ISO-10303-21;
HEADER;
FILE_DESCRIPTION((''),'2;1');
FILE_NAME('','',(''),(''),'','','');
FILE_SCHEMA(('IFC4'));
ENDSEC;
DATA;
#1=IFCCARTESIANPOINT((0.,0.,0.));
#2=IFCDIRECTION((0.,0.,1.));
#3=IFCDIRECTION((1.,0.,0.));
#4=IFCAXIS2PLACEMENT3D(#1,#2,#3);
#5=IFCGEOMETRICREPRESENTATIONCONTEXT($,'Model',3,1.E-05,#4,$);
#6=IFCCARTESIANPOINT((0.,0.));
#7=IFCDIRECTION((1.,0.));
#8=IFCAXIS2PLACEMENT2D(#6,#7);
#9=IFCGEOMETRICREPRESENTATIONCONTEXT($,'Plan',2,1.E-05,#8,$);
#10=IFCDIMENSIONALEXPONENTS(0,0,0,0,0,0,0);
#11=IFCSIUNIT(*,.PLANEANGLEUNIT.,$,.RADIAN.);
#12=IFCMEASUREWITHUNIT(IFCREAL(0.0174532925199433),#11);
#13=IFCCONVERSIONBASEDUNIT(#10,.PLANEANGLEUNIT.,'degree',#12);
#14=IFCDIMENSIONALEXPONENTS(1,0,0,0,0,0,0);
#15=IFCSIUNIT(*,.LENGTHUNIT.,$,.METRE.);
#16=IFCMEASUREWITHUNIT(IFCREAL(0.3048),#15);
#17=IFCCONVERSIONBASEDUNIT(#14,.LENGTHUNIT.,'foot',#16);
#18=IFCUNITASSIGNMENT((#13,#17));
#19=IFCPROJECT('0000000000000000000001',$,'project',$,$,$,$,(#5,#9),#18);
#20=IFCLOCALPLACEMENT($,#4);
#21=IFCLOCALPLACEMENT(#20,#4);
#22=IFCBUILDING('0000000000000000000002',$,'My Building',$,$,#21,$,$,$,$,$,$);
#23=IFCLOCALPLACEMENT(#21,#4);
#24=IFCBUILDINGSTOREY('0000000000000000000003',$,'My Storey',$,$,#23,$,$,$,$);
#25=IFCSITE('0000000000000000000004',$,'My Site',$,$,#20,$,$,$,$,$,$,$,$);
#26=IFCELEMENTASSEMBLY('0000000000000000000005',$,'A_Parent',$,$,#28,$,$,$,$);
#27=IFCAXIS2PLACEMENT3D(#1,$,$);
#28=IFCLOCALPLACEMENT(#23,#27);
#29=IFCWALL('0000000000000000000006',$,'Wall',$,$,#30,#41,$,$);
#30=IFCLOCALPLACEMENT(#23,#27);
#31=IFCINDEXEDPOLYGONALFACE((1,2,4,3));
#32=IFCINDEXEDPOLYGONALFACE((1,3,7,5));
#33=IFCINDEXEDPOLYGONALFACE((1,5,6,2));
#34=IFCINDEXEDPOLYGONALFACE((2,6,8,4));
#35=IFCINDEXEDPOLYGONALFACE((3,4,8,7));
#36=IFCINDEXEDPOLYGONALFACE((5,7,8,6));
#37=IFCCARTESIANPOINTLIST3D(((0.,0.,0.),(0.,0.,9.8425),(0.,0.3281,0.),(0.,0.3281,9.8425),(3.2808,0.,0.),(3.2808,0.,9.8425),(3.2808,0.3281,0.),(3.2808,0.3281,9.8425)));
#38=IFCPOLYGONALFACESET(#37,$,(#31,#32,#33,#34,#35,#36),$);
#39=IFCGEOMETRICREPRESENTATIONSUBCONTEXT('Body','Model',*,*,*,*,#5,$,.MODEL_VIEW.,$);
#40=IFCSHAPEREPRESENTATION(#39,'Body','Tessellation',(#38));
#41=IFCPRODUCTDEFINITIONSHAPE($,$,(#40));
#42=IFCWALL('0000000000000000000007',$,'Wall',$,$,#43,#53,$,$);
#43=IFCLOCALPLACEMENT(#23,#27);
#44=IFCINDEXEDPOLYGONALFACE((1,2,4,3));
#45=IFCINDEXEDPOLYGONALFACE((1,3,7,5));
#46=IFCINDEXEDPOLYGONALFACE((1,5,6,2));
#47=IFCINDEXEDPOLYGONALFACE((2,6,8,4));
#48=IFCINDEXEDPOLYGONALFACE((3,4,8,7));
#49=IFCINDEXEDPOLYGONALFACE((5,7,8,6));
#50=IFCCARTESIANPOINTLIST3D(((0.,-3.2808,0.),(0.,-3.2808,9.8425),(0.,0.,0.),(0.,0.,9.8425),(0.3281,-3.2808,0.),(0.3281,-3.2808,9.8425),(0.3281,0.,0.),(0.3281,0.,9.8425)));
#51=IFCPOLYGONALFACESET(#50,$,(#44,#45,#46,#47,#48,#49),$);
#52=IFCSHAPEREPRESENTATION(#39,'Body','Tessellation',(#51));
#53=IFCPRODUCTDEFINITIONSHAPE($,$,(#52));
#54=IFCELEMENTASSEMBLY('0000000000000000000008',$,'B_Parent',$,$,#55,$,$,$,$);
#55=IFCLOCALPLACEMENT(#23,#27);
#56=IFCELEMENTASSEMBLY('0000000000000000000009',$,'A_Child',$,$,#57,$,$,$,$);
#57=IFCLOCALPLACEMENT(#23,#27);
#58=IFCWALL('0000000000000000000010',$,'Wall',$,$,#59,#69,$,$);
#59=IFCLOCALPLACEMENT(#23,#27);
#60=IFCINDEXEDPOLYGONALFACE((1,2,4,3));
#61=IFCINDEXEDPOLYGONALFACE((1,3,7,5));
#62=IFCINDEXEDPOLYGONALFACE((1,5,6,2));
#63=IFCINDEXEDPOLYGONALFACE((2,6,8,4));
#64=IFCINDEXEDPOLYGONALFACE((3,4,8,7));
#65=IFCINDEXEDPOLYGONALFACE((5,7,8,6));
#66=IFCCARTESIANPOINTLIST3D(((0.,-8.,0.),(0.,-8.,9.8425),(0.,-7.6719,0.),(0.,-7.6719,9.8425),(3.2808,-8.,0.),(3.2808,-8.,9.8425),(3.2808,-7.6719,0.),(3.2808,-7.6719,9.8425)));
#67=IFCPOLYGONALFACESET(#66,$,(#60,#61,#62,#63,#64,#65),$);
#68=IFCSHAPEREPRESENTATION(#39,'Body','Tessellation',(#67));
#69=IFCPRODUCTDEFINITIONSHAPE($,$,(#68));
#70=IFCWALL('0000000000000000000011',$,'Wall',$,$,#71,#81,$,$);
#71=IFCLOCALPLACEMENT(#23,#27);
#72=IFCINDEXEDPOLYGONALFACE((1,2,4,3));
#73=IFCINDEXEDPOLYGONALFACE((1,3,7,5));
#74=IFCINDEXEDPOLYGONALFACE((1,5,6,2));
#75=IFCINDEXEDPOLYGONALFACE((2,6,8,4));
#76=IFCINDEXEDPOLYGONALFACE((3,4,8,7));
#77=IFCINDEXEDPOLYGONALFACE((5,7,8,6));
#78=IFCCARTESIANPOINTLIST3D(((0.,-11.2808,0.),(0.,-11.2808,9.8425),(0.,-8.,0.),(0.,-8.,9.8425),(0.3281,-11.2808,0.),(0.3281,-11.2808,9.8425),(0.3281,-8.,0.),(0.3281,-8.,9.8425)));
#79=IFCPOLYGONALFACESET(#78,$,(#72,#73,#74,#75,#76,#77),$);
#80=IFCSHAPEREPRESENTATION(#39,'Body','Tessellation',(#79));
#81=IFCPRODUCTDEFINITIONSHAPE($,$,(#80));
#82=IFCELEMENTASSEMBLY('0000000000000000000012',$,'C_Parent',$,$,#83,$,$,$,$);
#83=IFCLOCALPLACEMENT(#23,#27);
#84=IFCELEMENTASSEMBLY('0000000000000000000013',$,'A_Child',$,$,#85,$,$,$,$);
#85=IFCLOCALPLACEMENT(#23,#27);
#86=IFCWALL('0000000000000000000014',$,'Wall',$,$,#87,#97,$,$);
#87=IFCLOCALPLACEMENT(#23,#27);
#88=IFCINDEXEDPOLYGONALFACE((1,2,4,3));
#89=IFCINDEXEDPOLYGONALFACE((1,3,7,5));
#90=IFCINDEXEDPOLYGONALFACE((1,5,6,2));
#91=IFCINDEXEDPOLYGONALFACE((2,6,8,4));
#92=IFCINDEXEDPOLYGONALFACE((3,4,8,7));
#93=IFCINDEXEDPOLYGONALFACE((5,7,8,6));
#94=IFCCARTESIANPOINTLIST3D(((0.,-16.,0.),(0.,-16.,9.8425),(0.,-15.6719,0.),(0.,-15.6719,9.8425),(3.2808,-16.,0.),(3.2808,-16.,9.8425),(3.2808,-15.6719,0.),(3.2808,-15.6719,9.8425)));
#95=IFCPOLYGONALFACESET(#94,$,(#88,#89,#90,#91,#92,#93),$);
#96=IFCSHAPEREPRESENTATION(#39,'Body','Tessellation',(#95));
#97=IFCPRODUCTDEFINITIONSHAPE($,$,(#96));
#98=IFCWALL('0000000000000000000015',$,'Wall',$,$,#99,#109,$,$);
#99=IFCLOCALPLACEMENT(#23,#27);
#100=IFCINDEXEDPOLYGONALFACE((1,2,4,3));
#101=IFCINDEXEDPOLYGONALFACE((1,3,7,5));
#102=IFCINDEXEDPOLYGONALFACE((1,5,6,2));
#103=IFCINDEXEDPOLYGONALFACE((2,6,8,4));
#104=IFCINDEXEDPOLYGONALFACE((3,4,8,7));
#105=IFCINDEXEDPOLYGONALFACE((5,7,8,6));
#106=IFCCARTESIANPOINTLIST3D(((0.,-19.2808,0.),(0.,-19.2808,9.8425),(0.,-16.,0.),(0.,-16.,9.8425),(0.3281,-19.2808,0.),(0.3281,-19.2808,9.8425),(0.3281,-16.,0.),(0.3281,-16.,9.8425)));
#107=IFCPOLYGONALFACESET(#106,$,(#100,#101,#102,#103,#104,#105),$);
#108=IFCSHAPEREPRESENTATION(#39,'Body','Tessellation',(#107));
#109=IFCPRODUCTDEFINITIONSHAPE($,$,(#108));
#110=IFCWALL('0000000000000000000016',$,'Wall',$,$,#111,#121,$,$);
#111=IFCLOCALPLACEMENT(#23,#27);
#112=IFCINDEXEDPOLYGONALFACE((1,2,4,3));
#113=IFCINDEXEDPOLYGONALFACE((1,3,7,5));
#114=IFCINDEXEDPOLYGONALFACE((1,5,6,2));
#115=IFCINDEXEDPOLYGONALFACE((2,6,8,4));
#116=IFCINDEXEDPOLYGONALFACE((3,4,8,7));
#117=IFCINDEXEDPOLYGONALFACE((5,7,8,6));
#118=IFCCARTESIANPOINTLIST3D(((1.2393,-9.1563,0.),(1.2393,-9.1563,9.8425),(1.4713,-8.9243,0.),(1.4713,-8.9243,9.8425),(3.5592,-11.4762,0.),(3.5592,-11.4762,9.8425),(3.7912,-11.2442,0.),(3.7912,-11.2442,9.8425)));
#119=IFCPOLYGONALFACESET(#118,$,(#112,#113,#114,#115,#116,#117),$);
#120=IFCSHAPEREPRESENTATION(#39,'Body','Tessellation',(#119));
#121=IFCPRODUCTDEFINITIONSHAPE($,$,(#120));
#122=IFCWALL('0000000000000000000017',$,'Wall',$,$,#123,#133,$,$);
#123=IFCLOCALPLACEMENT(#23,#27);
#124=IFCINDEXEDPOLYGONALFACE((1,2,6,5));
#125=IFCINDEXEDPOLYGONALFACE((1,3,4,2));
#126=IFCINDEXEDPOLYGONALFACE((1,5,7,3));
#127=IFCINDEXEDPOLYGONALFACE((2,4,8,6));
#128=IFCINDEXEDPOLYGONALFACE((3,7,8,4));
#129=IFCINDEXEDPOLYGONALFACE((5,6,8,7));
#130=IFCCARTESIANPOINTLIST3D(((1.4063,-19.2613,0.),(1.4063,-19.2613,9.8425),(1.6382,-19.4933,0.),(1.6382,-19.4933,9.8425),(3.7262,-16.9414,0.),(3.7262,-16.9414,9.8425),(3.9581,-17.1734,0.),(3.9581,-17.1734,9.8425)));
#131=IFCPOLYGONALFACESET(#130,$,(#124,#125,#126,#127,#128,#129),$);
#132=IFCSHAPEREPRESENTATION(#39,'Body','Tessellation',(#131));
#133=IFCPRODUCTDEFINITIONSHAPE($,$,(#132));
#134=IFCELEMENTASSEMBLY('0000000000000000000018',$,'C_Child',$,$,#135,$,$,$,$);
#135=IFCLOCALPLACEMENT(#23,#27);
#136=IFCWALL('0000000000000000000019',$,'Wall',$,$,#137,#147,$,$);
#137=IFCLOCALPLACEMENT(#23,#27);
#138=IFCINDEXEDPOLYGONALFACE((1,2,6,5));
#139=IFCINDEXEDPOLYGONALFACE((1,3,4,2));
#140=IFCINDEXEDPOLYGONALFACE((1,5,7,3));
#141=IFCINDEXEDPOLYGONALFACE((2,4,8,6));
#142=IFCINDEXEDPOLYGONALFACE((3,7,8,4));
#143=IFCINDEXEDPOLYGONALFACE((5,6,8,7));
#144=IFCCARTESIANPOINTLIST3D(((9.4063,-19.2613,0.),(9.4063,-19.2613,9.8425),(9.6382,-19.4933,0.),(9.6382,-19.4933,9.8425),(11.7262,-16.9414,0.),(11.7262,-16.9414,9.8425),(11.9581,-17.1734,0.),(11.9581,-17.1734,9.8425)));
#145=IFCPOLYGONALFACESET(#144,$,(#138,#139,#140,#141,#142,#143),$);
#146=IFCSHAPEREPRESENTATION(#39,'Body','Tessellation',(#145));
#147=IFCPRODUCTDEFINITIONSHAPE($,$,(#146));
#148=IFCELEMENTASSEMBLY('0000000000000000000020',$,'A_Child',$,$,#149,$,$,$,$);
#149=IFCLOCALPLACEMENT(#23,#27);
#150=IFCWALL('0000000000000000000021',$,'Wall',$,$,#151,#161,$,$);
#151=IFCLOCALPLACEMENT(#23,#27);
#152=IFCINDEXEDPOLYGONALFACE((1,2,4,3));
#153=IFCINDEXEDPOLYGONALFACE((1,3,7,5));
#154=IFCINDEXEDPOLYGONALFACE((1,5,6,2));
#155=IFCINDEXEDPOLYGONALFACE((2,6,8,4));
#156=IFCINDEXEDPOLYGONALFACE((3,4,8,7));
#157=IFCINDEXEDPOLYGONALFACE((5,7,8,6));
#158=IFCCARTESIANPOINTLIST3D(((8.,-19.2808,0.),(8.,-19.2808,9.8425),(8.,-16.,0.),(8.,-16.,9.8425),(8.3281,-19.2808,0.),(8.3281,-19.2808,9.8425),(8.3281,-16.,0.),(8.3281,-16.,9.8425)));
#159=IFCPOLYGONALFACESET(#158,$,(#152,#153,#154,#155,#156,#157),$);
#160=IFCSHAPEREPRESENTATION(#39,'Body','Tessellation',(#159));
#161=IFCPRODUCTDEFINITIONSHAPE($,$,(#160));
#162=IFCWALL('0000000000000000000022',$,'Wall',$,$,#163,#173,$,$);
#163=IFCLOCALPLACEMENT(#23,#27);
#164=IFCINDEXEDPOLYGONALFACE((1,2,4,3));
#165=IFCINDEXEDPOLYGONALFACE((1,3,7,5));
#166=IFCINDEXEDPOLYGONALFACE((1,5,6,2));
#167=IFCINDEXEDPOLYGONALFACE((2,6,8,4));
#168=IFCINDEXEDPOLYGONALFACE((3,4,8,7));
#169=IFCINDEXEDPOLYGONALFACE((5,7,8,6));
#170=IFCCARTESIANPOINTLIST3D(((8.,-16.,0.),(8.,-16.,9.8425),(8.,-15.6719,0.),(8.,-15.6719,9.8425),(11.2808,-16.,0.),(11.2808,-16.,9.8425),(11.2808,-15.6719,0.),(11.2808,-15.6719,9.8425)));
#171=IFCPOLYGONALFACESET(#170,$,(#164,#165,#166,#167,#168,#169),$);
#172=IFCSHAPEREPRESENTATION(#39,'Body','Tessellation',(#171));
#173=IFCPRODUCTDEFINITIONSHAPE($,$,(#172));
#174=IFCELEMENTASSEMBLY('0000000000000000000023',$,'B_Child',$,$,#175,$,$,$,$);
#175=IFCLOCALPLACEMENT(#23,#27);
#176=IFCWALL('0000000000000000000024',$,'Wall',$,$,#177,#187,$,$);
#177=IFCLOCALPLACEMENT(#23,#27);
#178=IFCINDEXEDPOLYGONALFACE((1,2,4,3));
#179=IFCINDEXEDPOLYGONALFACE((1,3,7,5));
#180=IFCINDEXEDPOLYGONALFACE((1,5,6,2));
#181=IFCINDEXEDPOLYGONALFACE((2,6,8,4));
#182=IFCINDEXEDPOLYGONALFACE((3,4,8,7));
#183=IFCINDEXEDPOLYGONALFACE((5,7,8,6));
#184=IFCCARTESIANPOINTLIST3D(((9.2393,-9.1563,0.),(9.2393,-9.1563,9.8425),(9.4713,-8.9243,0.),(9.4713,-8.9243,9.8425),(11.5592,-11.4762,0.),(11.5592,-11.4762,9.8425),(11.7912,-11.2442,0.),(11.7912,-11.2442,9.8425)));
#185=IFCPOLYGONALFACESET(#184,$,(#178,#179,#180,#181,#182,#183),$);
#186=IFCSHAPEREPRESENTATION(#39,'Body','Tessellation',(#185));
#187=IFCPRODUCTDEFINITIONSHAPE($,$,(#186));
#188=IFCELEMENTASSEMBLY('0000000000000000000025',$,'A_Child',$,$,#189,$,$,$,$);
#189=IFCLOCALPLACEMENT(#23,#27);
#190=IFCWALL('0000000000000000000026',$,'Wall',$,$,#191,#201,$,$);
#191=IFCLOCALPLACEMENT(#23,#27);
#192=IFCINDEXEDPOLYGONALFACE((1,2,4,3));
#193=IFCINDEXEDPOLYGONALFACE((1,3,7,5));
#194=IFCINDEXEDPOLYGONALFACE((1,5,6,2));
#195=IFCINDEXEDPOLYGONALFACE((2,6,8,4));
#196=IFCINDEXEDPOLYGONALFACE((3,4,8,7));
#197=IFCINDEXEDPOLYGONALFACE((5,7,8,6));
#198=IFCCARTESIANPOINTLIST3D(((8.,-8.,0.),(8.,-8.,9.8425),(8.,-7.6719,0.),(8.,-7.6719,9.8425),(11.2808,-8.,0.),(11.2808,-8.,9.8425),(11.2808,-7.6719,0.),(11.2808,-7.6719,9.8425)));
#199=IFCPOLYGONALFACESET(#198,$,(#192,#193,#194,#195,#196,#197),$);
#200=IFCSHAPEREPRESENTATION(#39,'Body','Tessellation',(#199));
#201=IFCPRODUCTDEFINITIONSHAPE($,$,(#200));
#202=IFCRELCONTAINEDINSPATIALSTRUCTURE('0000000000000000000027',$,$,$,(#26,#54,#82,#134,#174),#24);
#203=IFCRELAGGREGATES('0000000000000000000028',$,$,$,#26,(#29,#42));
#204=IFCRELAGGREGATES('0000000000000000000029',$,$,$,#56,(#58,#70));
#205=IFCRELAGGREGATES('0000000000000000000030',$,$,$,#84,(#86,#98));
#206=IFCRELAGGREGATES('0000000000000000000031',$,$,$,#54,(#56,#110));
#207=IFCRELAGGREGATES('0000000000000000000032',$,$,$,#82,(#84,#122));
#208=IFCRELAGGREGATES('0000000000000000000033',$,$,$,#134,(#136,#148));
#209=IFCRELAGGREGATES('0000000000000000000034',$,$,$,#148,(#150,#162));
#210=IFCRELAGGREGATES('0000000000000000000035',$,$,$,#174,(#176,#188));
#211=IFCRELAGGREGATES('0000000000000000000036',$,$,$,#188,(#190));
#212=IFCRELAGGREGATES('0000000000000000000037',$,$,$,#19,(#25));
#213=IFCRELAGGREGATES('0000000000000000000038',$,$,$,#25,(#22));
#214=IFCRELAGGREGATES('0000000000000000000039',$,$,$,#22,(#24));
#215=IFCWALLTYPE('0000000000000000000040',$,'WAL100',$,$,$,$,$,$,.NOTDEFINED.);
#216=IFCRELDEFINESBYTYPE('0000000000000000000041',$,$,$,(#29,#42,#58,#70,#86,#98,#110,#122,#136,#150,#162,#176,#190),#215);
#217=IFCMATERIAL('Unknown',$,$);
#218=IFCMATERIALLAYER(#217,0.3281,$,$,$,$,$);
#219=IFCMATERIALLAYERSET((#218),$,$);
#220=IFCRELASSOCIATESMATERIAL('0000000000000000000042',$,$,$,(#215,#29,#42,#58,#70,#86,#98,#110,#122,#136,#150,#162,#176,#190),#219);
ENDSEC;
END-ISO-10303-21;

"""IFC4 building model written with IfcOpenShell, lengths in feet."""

from ifc_helpers import new_model, entity, si_unit, converted_unit, frame, origin_with_axes, origin_2d_with_axis, place, context, subcontext, project, spatial, indexed_curve, outline, extrude, material, layer, layer_set, layer_usage, type_object, element, aggregate, save


model = new_model("IFC4")

# Units and contexts
model_context = context("Model", 3, precision=1e-05, world=origin_with_axes())
plan_context = context("Plan", 2, precision=1e-05, world=origin_2d_with_axis())
body_context = subcontext(model_context, "Body", "Model", "MODEL_VIEW")
ifc_project = project(units=[converted_unit("PLANEANGLEUNIT", "degree", entity("IfcReal", 0.0174532925199433), si_unit("PLANEANGLEUNIT", "RADIAN"), dimensions=[0, 0, 0, 0, 0, 0, 0]), converted_unit("LENGTHUNIT", "foot", entity("IfcReal", 0.3048), si_unit("LENGTHUNIT", "METRE"), dimensions=[1, 0, 0, 0, 0, 0, 0])], contexts=[model_context, plan_context])

# Site, building, storey
site_placement = place(None, origin_with_axes())
site = spatial("IfcSite", under=ifc_project, at=site_placement, Name="My Site")
building_placement = place(site_placement, origin_with_axes())
building = spatial("IfcBuilding", under=site, at=building_placement, Name="My Building")
storey_placement = place(building_placement, origin_with_axes())
storey = spatial("IfcBuildingStorey", under=building, at=storey_placement, Name="My Storey")

# Element assembly, walls
assembly_1_placement = place(storey_placement, origin_with_axes())
assembly_1 = element("IfcElementAssembly", 1, at=assembly_1_placement, inside=storey, Name="A_Parent")
ifc_material = material(Name="Unknown")
ifc_layer = layer(ifc_material, 0.3281)
ifc_layer_set = layer_set([ifc_layer])
ifc_layer_usage_1 = layer_usage(ifc_layer_set, "AXIS2", "POSITIVE", 0.0)
wall_type = type_object("IfcWallType", Name="WAL100", PredefinedType="NOTDEFINED", material=ifc_layer_set)
wall_1_placement = place(assembly_1_placement, origin_with_axes())
wall_1 = element("IfcWall", 2, at=wall_1_placement, type_object=wall_type, material=ifc_layer_usage_1, Name="Wall", context=body_context, shape_type="SweptSolid", body=[
    extrude(outline(indexed_curve([(0.0, 0.0), (0.0, 0.3281), (3.2808, 0.3281), (3.2808, 0.0), (0.0, 0.0)], self_intersect=False)), origin_with_axes(), (0.0, 0.0, 1.0), 9.8425),
])
ifc_layer_usage_2 = layer_usage(ifc_layer_set, "AXIS2", "POSITIVE", 0.0)
wall_2_placement = place(assembly_1_placement, frame((0.0, 0.0, 0.0), z_axis=(0.0, 0.0, 1.0), x_axis=(0.0, -1.0, 0.0)))
wall_2 = element("IfcWall", 3, at=wall_2_placement, type_object=wall_type, material=ifc_layer_usage_2, Name="Wall", context=body_context, shape_type="SweptSolid", body=[
    extrude(outline(indexed_curve([(0.0, 0.0), (0.0, 0.3281), (3.2808, 0.3281), (3.2808, 0.0), (0.0, 0.0)], self_intersect=False)), origin_with_axes(), (0.0, 0.0, 1.0), 9.8425),
])
aggregate(assembly_1, [wall_1, wall_2])

# Element assemblies, walls
assembly_2_placement = place(storey_placement, origin_with_axes())
assembly_2 = element("IfcElementAssembly", 4, at=assembly_2_placement, inside=storey, Name="B_Parent")
assembly_3_placement = place(assembly_2_placement, frame((0.0, -8.0, 0.0), z_axis=(0.0, 0.0, 1.0), x_axis=(1.0, 0.0, 0.0)))
assembly_3 = element("IfcElementAssembly", 5, at=assembly_3_placement, Name="A_Child")
ifc_layer_usage_3 = layer_usage(ifc_layer_set, "AXIS2", "POSITIVE", 0.0)
wall_3_placement = place(assembly_3_placement, origin_with_axes())
wall_3 = element("IfcWall", 6, at=wall_3_placement, type_object=wall_type, material=ifc_layer_usage_3, Name="Wall", context=body_context, shape_type="SweptSolid", body=[
    extrude(outline(indexed_curve([(0.0, 0.0), (0.0, 0.3281), (3.2808, 0.3281), (3.2808, 0.0), (0.0, 0.0)], self_intersect=False)), origin_with_axes(), (0.0, 0.0, 1.0), 9.8425),
])
ifc_layer_usage_4 = layer_usage(ifc_layer_set, "AXIS2", "POSITIVE", 0.0)
wall_4_placement = place(assembly_3_placement, frame((0.0, 0.0, 0.0), z_axis=(0.0, 0.0, 1.0), x_axis=(0.0, -1.0, 0.0)))
wall_4 = element("IfcWall", 7, at=wall_4_placement, type_object=wall_type, material=ifc_layer_usage_4, Name="Wall", context=body_context, shape_type="SweptSolid", body=[
    extrude(outline(indexed_curve([(0.0, 0.0), (0.0, 0.3281), (3.2808, 0.3281), (3.2808, 0.0), (0.0, 0.0)], self_intersect=False)), origin_with_axes(), (0.0, 0.0, 1.0), 9.8425),
])
aggregate(assembly_3, [wall_3, wall_4])
assembly_4_placement = place(storey_placement, origin_with_axes())
assembly_4 = element("IfcElementAssembly", 8, at=assembly_4_placement, inside=storey, Name="C_Parent")
assembly_5_placement = place(assembly_4_placement, frame((0.0, -16.0, 0.0), z_axis=(0.0, 0.0, 1.0), x_axis=(1.0, 0.0, 0.0)))
assembly_5 = element("IfcElementAssembly", 9, at=assembly_5_placement, Name="A_Child")
ifc_layer_usage_5 = layer_usage(ifc_layer_set, "AXIS2", "POSITIVE", 0.0)
wall_5_placement = place(assembly_5_placement, origin_with_axes())
wall_5 = element("IfcWall", 10, at=wall_5_placement, type_object=wall_type, material=ifc_layer_usage_5, Name="Wall", context=body_context, shape_type="SweptSolid", body=[
    extrude(outline(indexed_curve([(0.0, 0.0), (0.0, 0.3281), (3.2808, 0.3281), (3.2808, 0.0), (0.0, 0.0)], self_intersect=False)), origin_with_axes(), (0.0, 0.0, 1.0), 9.8425),
])
ifc_layer_usage_6 = layer_usage(ifc_layer_set, "AXIS2", "POSITIVE", 0.0)
wall_6_placement = place(assembly_5_placement, frame((0.0, 0.0, 0.0), z_axis=(0.0, 0.0, 1.0), x_axis=(0.0, -1.0, 0.0)))
wall_6 = element("IfcWall", 11, at=wall_6_placement, type_object=wall_type, material=ifc_layer_usage_6, Name="Wall", context=body_context, shape_type="SweptSolid", body=[
    extrude(outline(indexed_curve([(0.0, 0.0), (0.0, 0.3281), (3.2808, 0.3281), (3.2808, 0.0), (0.0, 0.0)], self_intersect=False)), origin_with_axes(), (0.0, 0.0, 1.0), 9.8425),
])
aggregate(assembly_5, [wall_5, wall_6])

# Walls
ifc_layer_usage_7 = layer_usage(ifc_layer_set, "AXIS2", "POSITIVE", 0.0)
wall_7_placement = place(assembly_2_placement, frame((1.2393, -9.1563, 0.0), z_axis=(0.0, 0.0, 1.0), x_axis=(0.707107, -0.707107, 0.0)))
wall_7 = element("IfcWall", 12, at=wall_7_placement, type_object=wall_type, material=ifc_layer_usage_7, Name="Wall", context=body_context, shape_type="SweptSolid", body=[
    extrude(outline(indexed_curve([(0.0, 0.0), (0.0, 0.3281), (3.2808, 0.3281), (3.2808, 0.0), (0.0, 0.0)], self_intersect=False)), origin_with_axes(), (0.0, 0.0, 1.0), 9.8425),
])
aggregate(assembly_2, [assembly_3, wall_7])
ifc_layer_usage_8 = layer_usage(ifc_layer_set, "AXIS2", "POSITIVE", 0.0)
wall_8_placement = place(assembly_4_placement, frame((1.6382, -19.4933, 0.0), z_axis=(0.0, 0.0, 1.0), x_axis=(0.707107, 0.707107, 0.0)))
wall_8 = element("IfcWall", 13, at=wall_8_placement, type_object=wall_type, material=ifc_layer_usage_8, Name="Wall", context=body_context, shape_type="SweptSolid", body=[
    extrude(outline(indexed_curve([(0.0, 0.0), (0.0, 0.3281), (3.2808, 0.3281), (3.2808, 0.0), (0.0, 0.0)], self_intersect=False)), origin_with_axes(), (0.0, 0.0, 1.0), 9.8425),
])
aggregate(assembly_4, [assembly_5, wall_8])

# Element assemblies, walls
assembly_6_placement = place(storey_placement, frame((8.0, 0.0, 0.0), z_axis=(0.0, 0.0, 1.0), x_axis=(1.0, 0.0, 0.0)))
assembly_6 = element("IfcElementAssembly", 14, at=assembly_6_placement, inside=storey, Name="C_Child")
ifc_layer_usage_9 = layer_usage(ifc_layer_set, "AXIS2", "POSITIVE", 0.0)
wall_9_placement = place(assembly_6_placement, frame((1.6382, -19.4933, 0.0), z_axis=(0.0, 0.0, 1.0), x_axis=(0.707107, 0.707107, 0.0)))
wall_9 = element("IfcWall", 15, at=wall_9_placement, type_object=wall_type, material=ifc_layer_usage_9, Name="Wall", context=body_context, shape_type="SweptSolid", body=[
    extrude(outline(indexed_curve([(0.0, 0.0), (0.0, 0.3281), (3.2808, 0.3281), (3.2808, 0.0), (0.0, 0.0)], self_intersect=False)), origin_with_axes(), (0.0, 0.0, 1.0), 9.8425),
])
assembly_7_placement = place(assembly_6_placement, frame((0.0, -16.0, 0.0), z_axis=(0.0, 0.0, 1.0), x_axis=(1.0, 0.0, 0.0)))
assembly_7 = element("IfcElementAssembly", 16, at=assembly_7_placement, Name="A_Child")
aggregate(assembly_6, [wall_9, assembly_7])
ifc_layer_usage_10 = layer_usage(ifc_layer_set, "AXIS2", "POSITIVE", 0.0)
wall_10_placement = place(assembly_7_placement, frame((0.0, 0.0, 0.0), z_axis=(0.0, 0.0, 1.0), x_axis=(0.0, -1.0, 0.0)))
wall_10 = element("IfcWall", 17, at=wall_10_placement, type_object=wall_type, material=ifc_layer_usage_10, Name="Wall", context=body_context, shape_type="SweptSolid", body=[
    extrude(outline(indexed_curve([(0.0, 0.0), (0.0, 0.3281), (3.2808, 0.3281), (3.2808, 0.0), (0.0, 0.0)], self_intersect=False)), origin_with_axes(), (0.0, 0.0, 1.0), 9.8425),
])
ifc_layer_usage_11 = layer_usage(ifc_layer_set, "AXIS2", "POSITIVE", 0.0)
wall_11_placement = place(assembly_7_placement, origin_with_axes())
wall_11 = element("IfcWall", 18, at=wall_11_placement, type_object=wall_type, material=ifc_layer_usage_11, Name="Wall", context=body_context, shape_type="SweptSolid", body=[
    extrude(outline(indexed_curve([(0.0, 0.0), (0.0, 0.3281), (3.2808, 0.3281), (3.2808, 0.0), (0.0, 0.0)], self_intersect=False)), origin_with_axes(), (0.0, 0.0, 1.0), 9.8425),
])
aggregate(assembly_7, [wall_10, wall_11])
assembly_8_placement = place(storey_placement, frame((8.0, 0.0, 0.0), z_axis=(0.0, 0.0, 1.0), x_axis=(1.0, 0.0, 0.0)))
assembly_8 = element("IfcElementAssembly", 19, at=assembly_8_placement, inside=storey, Name="B_Child")
ifc_layer_usage_12 = layer_usage(ifc_layer_set, "AXIS2", "POSITIVE", 0.0)
wall_12_placement = place(assembly_8_placement, frame((1.2393, -9.1563, 0.0), z_axis=(0.0, 0.0, 1.0), x_axis=(0.707107, -0.707107, 0.0)))
wall_12 = element("IfcWall", 20, at=wall_12_placement, type_object=wall_type, material=ifc_layer_usage_12, Name="Wall", context=body_context, shape_type="SweptSolid", body=[
    extrude(outline(indexed_curve([(0.0, 0.0), (0.0, 0.3281), (3.2808, 0.3281), (3.2808, 0.0), (0.0, 0.0)], self_intersect=False)), origin_with_axes(), (0.0, 0.0, 1.0), 9.8425),
])
assembly_9_placement = place(assembly_8_placement, frame((0.0, -8.0, 0.0), z_axis=(0.0, 0.0, 1.0), x_axis=(1.0, 0.0, 0.0)))
assembly_9 = element("IfcElementAssembly", 21, at=assembly_9_placement, Name="A_Child")
aggregate(assembly_8, [wall_12, assembly_9])
ifc_layer_usage_13 = layer_usage(ifc_layer_set, "AXIS2", "POSITIVE", 0.0)
wall_13_placement = place(assembly_9_placement, origin_with_axes())
wall_13 = element("IfcWall", 22, at=wall_13_placement, type_object=wall_type, material=ifc_layer_usage_13, Name="Wall", context=body_context, shape_type="SweptSolid", body=[
    extrude(outline(indexed_curve([(0.0, 0.0), (0.0, 0.3281), (3.2808, 0.3281), (3.2808, 0.0), (0.0, 0.0)], self_intersect=False)), origin_with_axes(), (0.0, 0.0, 1.0), 9.8425),
])
aggregate(assembly_9, [wall_13])

save(model, "model.ifc")
